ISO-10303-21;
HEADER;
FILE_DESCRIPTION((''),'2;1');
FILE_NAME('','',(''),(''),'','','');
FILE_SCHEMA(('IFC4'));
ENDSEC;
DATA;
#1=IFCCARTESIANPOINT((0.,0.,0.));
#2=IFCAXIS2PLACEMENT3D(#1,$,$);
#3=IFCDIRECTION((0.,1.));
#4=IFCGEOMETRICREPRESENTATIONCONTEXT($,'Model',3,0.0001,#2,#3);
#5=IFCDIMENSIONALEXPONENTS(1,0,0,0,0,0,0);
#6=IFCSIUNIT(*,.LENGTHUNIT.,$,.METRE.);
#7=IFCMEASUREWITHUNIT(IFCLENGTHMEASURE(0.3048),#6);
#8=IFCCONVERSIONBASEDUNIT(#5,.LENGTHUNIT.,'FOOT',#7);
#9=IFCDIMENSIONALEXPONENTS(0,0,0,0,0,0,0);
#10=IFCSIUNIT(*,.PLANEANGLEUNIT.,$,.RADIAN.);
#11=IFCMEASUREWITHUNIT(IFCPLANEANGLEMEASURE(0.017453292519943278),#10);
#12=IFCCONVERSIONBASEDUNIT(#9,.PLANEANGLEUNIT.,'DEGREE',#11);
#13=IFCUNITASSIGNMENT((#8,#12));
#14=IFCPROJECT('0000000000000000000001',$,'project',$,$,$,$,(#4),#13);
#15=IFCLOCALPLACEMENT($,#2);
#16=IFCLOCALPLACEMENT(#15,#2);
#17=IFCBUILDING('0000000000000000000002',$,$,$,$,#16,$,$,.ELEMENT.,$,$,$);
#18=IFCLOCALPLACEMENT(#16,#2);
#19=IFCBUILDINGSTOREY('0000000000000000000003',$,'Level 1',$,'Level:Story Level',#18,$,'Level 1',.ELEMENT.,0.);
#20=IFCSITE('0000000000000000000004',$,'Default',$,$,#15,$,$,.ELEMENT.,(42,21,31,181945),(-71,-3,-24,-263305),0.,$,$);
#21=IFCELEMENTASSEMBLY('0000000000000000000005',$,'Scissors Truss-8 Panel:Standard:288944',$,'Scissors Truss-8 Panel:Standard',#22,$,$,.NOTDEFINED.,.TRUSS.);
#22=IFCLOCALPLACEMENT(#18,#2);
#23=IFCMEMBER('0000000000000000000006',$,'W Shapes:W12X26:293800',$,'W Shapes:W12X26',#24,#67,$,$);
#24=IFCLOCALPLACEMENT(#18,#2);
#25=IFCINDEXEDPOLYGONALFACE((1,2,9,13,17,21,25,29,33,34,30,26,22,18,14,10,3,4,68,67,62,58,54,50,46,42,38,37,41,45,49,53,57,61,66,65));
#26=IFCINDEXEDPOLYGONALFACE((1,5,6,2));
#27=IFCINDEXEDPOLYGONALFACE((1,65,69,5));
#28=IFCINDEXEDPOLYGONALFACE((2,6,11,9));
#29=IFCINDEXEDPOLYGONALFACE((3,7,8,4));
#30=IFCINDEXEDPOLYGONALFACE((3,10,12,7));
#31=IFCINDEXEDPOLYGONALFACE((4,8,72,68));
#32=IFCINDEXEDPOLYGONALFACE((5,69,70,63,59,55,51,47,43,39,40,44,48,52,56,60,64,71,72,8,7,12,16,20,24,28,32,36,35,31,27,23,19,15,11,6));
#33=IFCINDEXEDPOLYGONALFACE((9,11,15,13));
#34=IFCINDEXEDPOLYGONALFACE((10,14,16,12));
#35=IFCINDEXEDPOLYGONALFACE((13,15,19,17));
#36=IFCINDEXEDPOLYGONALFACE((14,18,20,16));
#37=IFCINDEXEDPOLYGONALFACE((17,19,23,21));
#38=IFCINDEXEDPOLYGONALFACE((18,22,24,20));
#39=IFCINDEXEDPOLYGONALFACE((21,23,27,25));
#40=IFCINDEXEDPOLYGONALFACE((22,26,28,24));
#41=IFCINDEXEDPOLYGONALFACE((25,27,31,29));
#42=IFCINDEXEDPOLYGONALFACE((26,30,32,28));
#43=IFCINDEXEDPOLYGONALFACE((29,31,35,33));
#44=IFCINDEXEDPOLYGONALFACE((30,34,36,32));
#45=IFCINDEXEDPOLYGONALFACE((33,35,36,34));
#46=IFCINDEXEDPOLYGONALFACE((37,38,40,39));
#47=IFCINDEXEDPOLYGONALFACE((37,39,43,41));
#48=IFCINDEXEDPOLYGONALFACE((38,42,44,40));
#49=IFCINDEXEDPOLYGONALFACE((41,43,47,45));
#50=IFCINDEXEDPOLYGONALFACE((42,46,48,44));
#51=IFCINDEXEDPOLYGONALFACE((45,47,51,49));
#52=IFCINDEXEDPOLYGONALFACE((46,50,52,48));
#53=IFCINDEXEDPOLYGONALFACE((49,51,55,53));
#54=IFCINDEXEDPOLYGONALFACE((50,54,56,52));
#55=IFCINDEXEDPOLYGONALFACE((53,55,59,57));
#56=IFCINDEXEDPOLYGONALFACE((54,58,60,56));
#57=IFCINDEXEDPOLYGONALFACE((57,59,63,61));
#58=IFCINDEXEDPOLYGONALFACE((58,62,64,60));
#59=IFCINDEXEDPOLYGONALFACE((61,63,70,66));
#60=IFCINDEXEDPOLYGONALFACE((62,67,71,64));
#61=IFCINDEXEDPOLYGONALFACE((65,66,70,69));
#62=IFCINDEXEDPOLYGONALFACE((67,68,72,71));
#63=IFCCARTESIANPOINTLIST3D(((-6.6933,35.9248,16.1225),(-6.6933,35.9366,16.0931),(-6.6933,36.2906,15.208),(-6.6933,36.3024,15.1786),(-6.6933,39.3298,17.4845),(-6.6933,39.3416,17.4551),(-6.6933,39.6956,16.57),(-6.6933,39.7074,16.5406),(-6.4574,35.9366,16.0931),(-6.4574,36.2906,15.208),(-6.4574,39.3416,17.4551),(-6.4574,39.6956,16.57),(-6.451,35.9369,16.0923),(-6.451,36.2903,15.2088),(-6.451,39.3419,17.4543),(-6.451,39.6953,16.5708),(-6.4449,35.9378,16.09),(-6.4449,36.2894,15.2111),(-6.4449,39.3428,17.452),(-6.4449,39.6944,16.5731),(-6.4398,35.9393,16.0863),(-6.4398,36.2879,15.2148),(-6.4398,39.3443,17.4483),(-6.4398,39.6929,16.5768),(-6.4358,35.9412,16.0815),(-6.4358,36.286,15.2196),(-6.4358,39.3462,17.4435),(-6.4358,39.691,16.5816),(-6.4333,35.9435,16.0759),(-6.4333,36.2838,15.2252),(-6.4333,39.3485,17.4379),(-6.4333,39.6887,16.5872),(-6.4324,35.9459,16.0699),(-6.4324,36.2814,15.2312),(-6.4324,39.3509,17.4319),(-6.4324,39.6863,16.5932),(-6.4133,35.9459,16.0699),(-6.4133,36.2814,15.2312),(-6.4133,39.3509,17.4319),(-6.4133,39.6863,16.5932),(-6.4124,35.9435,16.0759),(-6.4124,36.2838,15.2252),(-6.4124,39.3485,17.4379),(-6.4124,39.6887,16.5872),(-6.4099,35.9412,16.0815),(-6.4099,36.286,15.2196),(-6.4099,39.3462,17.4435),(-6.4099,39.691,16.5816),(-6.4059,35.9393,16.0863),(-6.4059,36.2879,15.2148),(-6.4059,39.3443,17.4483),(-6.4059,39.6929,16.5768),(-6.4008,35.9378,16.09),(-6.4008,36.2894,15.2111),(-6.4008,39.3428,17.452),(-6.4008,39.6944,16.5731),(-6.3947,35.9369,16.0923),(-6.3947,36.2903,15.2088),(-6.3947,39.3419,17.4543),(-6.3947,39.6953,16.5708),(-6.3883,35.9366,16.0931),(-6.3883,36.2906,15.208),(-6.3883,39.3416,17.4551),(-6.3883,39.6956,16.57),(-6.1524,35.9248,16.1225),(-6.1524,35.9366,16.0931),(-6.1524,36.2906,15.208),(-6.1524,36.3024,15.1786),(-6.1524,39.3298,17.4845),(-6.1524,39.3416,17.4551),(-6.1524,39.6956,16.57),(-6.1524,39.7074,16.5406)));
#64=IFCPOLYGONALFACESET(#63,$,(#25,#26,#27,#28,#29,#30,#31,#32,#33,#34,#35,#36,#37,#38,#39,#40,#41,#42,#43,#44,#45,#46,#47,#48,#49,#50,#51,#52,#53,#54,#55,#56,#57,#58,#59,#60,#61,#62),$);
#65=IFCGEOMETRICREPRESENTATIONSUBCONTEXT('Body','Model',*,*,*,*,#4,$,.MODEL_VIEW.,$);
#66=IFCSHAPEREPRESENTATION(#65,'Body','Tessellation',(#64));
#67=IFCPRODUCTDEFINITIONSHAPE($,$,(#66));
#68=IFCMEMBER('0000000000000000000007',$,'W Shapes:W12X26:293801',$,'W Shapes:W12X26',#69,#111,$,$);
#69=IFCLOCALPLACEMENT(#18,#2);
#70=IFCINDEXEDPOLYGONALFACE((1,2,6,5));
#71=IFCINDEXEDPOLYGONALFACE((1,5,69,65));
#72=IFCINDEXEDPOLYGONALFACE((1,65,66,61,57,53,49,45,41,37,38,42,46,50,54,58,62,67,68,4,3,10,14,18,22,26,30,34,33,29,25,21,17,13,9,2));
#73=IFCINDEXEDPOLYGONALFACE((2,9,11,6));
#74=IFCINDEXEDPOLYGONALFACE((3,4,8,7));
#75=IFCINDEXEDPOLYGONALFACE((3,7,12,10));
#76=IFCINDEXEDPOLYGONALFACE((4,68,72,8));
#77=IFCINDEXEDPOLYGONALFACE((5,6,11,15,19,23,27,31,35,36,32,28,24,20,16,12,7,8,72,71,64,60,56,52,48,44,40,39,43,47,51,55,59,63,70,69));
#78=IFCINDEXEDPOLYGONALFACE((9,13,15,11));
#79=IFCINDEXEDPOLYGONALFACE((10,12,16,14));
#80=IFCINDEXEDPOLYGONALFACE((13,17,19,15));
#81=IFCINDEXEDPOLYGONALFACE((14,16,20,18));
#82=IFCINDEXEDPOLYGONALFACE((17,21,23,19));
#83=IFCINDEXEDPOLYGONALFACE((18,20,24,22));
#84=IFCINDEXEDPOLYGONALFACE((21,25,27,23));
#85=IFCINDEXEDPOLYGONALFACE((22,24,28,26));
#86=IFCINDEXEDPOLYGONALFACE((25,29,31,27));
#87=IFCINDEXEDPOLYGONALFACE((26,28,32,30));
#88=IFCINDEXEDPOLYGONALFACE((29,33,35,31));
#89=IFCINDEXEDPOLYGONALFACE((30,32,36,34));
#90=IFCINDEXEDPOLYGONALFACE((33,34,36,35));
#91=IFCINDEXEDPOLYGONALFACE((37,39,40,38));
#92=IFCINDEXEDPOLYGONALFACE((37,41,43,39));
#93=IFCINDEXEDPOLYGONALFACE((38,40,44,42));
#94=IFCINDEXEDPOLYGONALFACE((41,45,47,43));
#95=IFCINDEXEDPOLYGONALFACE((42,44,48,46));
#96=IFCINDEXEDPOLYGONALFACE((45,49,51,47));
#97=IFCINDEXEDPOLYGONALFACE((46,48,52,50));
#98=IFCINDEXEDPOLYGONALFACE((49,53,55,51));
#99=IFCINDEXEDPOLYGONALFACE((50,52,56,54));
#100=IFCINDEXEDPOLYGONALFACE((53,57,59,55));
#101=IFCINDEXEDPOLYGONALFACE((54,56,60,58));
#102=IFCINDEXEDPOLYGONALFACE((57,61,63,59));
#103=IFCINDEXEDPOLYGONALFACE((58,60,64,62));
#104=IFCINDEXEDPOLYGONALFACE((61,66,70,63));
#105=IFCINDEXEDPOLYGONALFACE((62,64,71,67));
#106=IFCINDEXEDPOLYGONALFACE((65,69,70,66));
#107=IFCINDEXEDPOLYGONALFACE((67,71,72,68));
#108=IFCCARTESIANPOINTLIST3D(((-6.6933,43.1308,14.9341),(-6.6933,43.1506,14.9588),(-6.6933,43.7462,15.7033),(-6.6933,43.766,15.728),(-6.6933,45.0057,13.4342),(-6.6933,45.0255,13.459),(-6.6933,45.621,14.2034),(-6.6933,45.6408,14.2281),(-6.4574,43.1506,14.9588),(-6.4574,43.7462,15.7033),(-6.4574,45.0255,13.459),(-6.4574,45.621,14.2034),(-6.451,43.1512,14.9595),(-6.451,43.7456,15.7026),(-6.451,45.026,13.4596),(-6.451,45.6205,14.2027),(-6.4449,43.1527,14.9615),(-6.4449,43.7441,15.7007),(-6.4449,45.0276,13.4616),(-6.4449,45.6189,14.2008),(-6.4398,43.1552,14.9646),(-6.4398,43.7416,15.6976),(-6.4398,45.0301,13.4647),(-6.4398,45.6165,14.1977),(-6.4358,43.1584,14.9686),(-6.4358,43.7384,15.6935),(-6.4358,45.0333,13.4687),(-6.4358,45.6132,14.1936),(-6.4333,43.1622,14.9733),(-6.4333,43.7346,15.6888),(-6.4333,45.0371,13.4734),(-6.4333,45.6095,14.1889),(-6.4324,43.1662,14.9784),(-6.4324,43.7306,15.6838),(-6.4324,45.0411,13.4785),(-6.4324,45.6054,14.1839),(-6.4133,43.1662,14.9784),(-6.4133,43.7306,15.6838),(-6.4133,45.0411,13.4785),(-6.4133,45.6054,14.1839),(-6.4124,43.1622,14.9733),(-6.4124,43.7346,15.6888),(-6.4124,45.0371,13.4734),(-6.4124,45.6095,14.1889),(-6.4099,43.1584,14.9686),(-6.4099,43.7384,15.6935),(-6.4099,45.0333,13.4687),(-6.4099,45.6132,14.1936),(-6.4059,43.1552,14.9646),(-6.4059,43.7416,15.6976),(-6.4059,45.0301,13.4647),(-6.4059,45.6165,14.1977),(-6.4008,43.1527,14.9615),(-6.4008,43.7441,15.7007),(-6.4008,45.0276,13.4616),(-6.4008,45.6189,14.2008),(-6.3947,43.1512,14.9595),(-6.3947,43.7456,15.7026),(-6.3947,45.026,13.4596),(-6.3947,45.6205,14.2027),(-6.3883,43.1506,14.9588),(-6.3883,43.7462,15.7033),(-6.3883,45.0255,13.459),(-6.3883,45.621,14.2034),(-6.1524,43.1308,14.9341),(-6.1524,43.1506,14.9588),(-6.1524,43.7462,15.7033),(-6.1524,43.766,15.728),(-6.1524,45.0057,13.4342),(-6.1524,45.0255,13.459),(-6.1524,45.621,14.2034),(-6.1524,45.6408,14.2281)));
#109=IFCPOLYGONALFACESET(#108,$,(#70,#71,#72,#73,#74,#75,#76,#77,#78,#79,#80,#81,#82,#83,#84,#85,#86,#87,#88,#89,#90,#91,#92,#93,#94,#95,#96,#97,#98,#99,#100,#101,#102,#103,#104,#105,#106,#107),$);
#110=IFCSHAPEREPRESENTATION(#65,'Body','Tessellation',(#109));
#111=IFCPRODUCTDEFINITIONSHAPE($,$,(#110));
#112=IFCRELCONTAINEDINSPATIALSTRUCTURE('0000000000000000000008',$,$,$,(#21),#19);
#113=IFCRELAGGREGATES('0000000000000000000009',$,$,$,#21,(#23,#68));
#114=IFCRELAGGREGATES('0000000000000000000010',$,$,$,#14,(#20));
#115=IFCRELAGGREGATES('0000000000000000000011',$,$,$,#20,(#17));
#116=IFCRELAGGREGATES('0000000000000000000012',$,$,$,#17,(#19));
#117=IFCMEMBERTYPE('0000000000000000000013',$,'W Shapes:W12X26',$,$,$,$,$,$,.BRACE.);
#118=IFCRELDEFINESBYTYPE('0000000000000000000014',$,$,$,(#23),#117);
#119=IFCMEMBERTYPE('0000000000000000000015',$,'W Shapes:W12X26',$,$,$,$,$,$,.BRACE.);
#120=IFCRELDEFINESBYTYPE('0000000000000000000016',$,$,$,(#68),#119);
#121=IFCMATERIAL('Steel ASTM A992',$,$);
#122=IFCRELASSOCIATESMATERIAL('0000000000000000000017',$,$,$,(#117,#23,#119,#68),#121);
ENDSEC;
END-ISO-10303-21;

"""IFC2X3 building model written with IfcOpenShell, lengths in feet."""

from ifc_helpers import new_model, entity, si_unit, converted_unit, direction, frame, frame_2d, origin, place, context, subcontext, project, spatial, polyline, circle_curve, parameter, trimmed, segment, composite_curve, outline, extrude, source, transform, mapped, material, type_object, type_shapes, element, aggregate, save


model = new_model("IFC2X3")

# Units and contexts
model_context = context("Model", 3, precision=0.0001, world=origin(), true_north=direction((0.0, 1.0)))
body_context = subcontext(model_context, "Body", "Model", "MODEL_VIEW")
ifc_project = project(units=[converted_unit("LENGTHUNIT", "FOOT", entity("IfcLengthMeasure", 0.3048), si_unit("LENGTHUNIT", "METRE"), dimensions=[1, 0, 0, 0, 0, 0, 0]), converted_unit("PLANEANGLEUNIT", "DEGREE", entity("IfcPlaneAngleMeasure", 0.017453292519943278), si_unit("PLANEANGLEUNIT", "RADIAN"), dimensions=[0, 0, 0, 0, 0, 0, 0])], contexts=[model_context])

# Site, building, storey
site_placement = place(None, origin())
site = spatial("IfcSite", under=ifc_project, at=site_placement, Name="Default", CompositionType="ELEMENT", RefLatitude=(42, 21, 31, 181945), RefLongitude=(-71, -3, -24, -263305), RefElevation=0.0)
building_placement = place(site_placement, origin())
building = spatial("IfcBuilding", under=site, at=building_placement, CompositionType="ELEMENT")
storey_placement = place(building_placement, origin())
storey = spatial("IfcBuildingStorey", under=building, at=storey_placement, Name="Level 1", ObjectType="Level:Story Level", LongName="Level 1", CompositionType="ELEMENT", Elevation=0.0)

# Element assembly, members
assembly_placement = place(storey_placement, origin())
assembly = element("IfcElementAssembly", 1, at=assembly_placement, inside=storey, Name="Scissors Truss-8 Panel:Standard:288944", ObjectType="Scissors Truss-8 Panel:Standard", AssemblyPlace="NOTDEFINED", PredefinedType="TRUSS")
ifc_material = material(Name="Steel ASTM A992")
member_type_1 = type_object("IfcMemberType", Name="W Shapes:W12X26", PredefinedType="BRACE", material=ifc_material)
shared_shape_1 = source(origin(), body_context, "Body", "SweptSolid", [
    extrude(outline(composite_curve([segment(polyline([(-0.2704, -0.4767), (-0.2704, -0.5083)]), True, "CONTINUOUS"), segment(polyline([(-0.2704, -0.5083), (0.2704, -0.5083)]), True, "CONTINUOUS"), segment(polyline([(0.2704, -0.5083), (0.2704, -0.4767)]), True, "CONTINUOUS"), segment(polyline([(0.2704, -0.4767), (0.0346, -0.4767)]), True, "CONTINUOUS"), segment(trimmed(circle_curve(frame_2d((0.0346, -0.4517), x_axis=(1.0, 0.0)), 0.025), [parameter(180.0)], [parameter(270.0)], True, "PARAMETER"), False, "CONTINUOUS"), segment(polyline([(0.0096, -0.4517), (0.0096, 0.4517)]), True, "CONTINUOUS"), segment(trimmed(circle_curve(frame_2d((0.0346, 0.4517), x_axis=(1.0, 0.0)), 0.025), [parameter(90.0)], [parameter(180.0)], True, "PARAMETER"), False, "CONTINUOUS"), segment(polyline([(0.0346, 0.4767), (0.2704, 0.4767)]), True, "CONTINUOUS"), segment(polyline([(0.2704, 0.4767), (0.2704, 0.5083)]), True, "CONTINUOUS"), segment(polyline([(0.2704, 0.5083), (-0.2704, 0.5083)]), True, "CONTINUOUS"), segment(polyline([(-0.2704, 0.5083), (-0.2704, 0.4767)]), True, "CONTINUOUS"), segment(polyline([(-0.2704, 0.4767), (-0.0346, 0.4767)]), True, "CONTINUOUS"), segment(trimmed(circle_curve(frame_2d((-0.0346, 0.4517), x_axis=(1.0, 0.0)), 0.025), [parameter(360.0)], [parameter(90.0)], True, "PARAMETER"), False, "CONTINUOUS"), segment(polyline([(-0.0096, 0.4517), (-0.0096, -0.4517)]), True, "CONTINUOUS"), segment(trimmed(circle_curve(frame_2d((-0.0346, -0.4517), x_axis=(1.0, 0.0)), 0.025), [parameter(270.0)], [parameter(360.0)], True, "PARAMETER"), False, "CONTINUOUS"), segment(polyline([(-0.0346, -0.4767), (-0.2704, -0.4767)]), True, "CONTINUOUS")], self_intersect=False)), frame((-1.6141, 0.0, 0.0), z_axis=(-1.0, 0.0, 0.0), x_axis=(0.0, -1.0, 0.0)), (0.0, 0.0, -1.0), 3.6673),
])
type_shapes(member_type_1, [shared_shape_1])
member_1_placement = place(assembly_placement, frame((-6.4228, 37.6122, 16.25), z_axis=(0.0, 0.371391, -0.928477), x_axis=(0.0, 0.928477, 0.371391)))
member_1 = element("IfcMember", 2, at=member_1_placement, type_object=member_type_1, material=ifc_material, Name="W Shapes:W12X26:293800", ObjectType="W Shapes:W12X26", context=body_context, shape_type="MappedRepresentation", body=[
    mapped(shared_shape_1, transform((0.0, 0.0, 0.0), scale=1.0)),
])
member_type_2 = type_object("IfcMemberType", Name="W Shapes:W12X26", PredefinedType="BRACE", material=ifc_material)
shared_shape_2 = source(origin(), body_context, "Body", "SweptSolid", [
    extrude(outline(composite_curve([segment(polyline([(-0.2704, -0.4767), (-0.2704, -0.5083)]), True, "CONTINUOUS"), segment(polyline([(-0.2704, -0.5083), (0.2704, -0.5083)]), True, "CONTINUOUS"), segment(polyline([(0.2704, -0.5083), (0.2704, -0.4767)]), True, "CONTINUOUS"), segment(polyline([(0.2704, -0.4767), (0.0346, -0.4767)]), True, "CONTINUOUS"), segment(trimmed(circle_curve(frame_2d((0.0346, -0.4517), x_axis=(1.0, 0.0)), 0.025), [parameter(180.0)], [parameter(270.0)], True, "PARAMETER"), False, "CONTINUOUS"), segment(polyline([(0.0096, -0.4517), (0.0096, 0.4517)]), True, "CONTINUOUS"), segment(trimmed(circle_curve(frame_2d((0.0346, 0.4517), x_axis=(1.0, 0.0)), 0.025), [parameter(90.0)], [parameter(180.0)], True, "PARAMETER"), False, "CONTINUOUS"), segment(polyline([(0.0346, 0.4767), (0.2704, 0.4767)]), True, "CONTINUOUS"), segment(polyline([(0.2704, 0.4767), (0.2704, 0.5083)]), True, "CONTINUOUS"), segment(polyline([(0.2704, 0.5083), (-0.2704, 0.5083)]), True, "CONTINUOUS"), segment(polyline([(-0.2704, 0.5083), (-0.2704, 0.4767)]), True, "CONTINUOUS"), segment(polyline([(-0.2704, 0.4767), (-0.0346, 0.4767)]), True, "CONTINUOUS"), segment(trimmed(circle_curve(frame_2d((-0.0346, 0.4517), x_axis=(1.0, 0.0)), 0.025), [parameter(360.0)], [parameter(90.0)], True, "PARAMETER"), False, "CONTINUOUS"), segment(polyline([(-0.0096, 0.4517), (-0.0096, -0.4517)]), True, "CONTINUOUS"), segment(trimmed(circle_curve(frame_2d((-0.0346, -0.4517), x_axis=(1.0, 0.0)), 0.025), [parameter(270.0)], [parameter(360.0)], True, "PARAMETER"), False, "CONTINUOUS"), segment(polyline([(-0.0346, -0.4767), (-0.2704, -0.4767)]), True, "CONTINUOUS")], self_intersect=False)), frame((-0.53, 0.0, 0.0), z_axis=(-1.0, 0.0, 0.0), x_axis=(0.0, -1.0, 0.0)), (0.0, 0.0, -1.0), 2.401),
])
type_shapes(member_type_2, [shared_shape_2])
member_2_placement = place(assembly_placement, frame((-6.4228, 43.8622, 15.0), z_axis=(0.0, -0.624695, -0.780869), x_axis=(0.0, 0.780869, -0.624695)))
member_2 = element("IfcMember", 3, at=member_2_placement, type_object=member_type_2, material=ifc_material, Name="W Shapes:W12X26:293801", ObjectType="W Shapes:W12X26", context=body_context, shape_type="MappedRepresentation", body=[
    mapped(shared_shape_2, transform((0.0, 0.0, 0.0), scale=1.0)),
])
aggregate(assembly, [member_1, member_2])

save(model, "model.ifc")
